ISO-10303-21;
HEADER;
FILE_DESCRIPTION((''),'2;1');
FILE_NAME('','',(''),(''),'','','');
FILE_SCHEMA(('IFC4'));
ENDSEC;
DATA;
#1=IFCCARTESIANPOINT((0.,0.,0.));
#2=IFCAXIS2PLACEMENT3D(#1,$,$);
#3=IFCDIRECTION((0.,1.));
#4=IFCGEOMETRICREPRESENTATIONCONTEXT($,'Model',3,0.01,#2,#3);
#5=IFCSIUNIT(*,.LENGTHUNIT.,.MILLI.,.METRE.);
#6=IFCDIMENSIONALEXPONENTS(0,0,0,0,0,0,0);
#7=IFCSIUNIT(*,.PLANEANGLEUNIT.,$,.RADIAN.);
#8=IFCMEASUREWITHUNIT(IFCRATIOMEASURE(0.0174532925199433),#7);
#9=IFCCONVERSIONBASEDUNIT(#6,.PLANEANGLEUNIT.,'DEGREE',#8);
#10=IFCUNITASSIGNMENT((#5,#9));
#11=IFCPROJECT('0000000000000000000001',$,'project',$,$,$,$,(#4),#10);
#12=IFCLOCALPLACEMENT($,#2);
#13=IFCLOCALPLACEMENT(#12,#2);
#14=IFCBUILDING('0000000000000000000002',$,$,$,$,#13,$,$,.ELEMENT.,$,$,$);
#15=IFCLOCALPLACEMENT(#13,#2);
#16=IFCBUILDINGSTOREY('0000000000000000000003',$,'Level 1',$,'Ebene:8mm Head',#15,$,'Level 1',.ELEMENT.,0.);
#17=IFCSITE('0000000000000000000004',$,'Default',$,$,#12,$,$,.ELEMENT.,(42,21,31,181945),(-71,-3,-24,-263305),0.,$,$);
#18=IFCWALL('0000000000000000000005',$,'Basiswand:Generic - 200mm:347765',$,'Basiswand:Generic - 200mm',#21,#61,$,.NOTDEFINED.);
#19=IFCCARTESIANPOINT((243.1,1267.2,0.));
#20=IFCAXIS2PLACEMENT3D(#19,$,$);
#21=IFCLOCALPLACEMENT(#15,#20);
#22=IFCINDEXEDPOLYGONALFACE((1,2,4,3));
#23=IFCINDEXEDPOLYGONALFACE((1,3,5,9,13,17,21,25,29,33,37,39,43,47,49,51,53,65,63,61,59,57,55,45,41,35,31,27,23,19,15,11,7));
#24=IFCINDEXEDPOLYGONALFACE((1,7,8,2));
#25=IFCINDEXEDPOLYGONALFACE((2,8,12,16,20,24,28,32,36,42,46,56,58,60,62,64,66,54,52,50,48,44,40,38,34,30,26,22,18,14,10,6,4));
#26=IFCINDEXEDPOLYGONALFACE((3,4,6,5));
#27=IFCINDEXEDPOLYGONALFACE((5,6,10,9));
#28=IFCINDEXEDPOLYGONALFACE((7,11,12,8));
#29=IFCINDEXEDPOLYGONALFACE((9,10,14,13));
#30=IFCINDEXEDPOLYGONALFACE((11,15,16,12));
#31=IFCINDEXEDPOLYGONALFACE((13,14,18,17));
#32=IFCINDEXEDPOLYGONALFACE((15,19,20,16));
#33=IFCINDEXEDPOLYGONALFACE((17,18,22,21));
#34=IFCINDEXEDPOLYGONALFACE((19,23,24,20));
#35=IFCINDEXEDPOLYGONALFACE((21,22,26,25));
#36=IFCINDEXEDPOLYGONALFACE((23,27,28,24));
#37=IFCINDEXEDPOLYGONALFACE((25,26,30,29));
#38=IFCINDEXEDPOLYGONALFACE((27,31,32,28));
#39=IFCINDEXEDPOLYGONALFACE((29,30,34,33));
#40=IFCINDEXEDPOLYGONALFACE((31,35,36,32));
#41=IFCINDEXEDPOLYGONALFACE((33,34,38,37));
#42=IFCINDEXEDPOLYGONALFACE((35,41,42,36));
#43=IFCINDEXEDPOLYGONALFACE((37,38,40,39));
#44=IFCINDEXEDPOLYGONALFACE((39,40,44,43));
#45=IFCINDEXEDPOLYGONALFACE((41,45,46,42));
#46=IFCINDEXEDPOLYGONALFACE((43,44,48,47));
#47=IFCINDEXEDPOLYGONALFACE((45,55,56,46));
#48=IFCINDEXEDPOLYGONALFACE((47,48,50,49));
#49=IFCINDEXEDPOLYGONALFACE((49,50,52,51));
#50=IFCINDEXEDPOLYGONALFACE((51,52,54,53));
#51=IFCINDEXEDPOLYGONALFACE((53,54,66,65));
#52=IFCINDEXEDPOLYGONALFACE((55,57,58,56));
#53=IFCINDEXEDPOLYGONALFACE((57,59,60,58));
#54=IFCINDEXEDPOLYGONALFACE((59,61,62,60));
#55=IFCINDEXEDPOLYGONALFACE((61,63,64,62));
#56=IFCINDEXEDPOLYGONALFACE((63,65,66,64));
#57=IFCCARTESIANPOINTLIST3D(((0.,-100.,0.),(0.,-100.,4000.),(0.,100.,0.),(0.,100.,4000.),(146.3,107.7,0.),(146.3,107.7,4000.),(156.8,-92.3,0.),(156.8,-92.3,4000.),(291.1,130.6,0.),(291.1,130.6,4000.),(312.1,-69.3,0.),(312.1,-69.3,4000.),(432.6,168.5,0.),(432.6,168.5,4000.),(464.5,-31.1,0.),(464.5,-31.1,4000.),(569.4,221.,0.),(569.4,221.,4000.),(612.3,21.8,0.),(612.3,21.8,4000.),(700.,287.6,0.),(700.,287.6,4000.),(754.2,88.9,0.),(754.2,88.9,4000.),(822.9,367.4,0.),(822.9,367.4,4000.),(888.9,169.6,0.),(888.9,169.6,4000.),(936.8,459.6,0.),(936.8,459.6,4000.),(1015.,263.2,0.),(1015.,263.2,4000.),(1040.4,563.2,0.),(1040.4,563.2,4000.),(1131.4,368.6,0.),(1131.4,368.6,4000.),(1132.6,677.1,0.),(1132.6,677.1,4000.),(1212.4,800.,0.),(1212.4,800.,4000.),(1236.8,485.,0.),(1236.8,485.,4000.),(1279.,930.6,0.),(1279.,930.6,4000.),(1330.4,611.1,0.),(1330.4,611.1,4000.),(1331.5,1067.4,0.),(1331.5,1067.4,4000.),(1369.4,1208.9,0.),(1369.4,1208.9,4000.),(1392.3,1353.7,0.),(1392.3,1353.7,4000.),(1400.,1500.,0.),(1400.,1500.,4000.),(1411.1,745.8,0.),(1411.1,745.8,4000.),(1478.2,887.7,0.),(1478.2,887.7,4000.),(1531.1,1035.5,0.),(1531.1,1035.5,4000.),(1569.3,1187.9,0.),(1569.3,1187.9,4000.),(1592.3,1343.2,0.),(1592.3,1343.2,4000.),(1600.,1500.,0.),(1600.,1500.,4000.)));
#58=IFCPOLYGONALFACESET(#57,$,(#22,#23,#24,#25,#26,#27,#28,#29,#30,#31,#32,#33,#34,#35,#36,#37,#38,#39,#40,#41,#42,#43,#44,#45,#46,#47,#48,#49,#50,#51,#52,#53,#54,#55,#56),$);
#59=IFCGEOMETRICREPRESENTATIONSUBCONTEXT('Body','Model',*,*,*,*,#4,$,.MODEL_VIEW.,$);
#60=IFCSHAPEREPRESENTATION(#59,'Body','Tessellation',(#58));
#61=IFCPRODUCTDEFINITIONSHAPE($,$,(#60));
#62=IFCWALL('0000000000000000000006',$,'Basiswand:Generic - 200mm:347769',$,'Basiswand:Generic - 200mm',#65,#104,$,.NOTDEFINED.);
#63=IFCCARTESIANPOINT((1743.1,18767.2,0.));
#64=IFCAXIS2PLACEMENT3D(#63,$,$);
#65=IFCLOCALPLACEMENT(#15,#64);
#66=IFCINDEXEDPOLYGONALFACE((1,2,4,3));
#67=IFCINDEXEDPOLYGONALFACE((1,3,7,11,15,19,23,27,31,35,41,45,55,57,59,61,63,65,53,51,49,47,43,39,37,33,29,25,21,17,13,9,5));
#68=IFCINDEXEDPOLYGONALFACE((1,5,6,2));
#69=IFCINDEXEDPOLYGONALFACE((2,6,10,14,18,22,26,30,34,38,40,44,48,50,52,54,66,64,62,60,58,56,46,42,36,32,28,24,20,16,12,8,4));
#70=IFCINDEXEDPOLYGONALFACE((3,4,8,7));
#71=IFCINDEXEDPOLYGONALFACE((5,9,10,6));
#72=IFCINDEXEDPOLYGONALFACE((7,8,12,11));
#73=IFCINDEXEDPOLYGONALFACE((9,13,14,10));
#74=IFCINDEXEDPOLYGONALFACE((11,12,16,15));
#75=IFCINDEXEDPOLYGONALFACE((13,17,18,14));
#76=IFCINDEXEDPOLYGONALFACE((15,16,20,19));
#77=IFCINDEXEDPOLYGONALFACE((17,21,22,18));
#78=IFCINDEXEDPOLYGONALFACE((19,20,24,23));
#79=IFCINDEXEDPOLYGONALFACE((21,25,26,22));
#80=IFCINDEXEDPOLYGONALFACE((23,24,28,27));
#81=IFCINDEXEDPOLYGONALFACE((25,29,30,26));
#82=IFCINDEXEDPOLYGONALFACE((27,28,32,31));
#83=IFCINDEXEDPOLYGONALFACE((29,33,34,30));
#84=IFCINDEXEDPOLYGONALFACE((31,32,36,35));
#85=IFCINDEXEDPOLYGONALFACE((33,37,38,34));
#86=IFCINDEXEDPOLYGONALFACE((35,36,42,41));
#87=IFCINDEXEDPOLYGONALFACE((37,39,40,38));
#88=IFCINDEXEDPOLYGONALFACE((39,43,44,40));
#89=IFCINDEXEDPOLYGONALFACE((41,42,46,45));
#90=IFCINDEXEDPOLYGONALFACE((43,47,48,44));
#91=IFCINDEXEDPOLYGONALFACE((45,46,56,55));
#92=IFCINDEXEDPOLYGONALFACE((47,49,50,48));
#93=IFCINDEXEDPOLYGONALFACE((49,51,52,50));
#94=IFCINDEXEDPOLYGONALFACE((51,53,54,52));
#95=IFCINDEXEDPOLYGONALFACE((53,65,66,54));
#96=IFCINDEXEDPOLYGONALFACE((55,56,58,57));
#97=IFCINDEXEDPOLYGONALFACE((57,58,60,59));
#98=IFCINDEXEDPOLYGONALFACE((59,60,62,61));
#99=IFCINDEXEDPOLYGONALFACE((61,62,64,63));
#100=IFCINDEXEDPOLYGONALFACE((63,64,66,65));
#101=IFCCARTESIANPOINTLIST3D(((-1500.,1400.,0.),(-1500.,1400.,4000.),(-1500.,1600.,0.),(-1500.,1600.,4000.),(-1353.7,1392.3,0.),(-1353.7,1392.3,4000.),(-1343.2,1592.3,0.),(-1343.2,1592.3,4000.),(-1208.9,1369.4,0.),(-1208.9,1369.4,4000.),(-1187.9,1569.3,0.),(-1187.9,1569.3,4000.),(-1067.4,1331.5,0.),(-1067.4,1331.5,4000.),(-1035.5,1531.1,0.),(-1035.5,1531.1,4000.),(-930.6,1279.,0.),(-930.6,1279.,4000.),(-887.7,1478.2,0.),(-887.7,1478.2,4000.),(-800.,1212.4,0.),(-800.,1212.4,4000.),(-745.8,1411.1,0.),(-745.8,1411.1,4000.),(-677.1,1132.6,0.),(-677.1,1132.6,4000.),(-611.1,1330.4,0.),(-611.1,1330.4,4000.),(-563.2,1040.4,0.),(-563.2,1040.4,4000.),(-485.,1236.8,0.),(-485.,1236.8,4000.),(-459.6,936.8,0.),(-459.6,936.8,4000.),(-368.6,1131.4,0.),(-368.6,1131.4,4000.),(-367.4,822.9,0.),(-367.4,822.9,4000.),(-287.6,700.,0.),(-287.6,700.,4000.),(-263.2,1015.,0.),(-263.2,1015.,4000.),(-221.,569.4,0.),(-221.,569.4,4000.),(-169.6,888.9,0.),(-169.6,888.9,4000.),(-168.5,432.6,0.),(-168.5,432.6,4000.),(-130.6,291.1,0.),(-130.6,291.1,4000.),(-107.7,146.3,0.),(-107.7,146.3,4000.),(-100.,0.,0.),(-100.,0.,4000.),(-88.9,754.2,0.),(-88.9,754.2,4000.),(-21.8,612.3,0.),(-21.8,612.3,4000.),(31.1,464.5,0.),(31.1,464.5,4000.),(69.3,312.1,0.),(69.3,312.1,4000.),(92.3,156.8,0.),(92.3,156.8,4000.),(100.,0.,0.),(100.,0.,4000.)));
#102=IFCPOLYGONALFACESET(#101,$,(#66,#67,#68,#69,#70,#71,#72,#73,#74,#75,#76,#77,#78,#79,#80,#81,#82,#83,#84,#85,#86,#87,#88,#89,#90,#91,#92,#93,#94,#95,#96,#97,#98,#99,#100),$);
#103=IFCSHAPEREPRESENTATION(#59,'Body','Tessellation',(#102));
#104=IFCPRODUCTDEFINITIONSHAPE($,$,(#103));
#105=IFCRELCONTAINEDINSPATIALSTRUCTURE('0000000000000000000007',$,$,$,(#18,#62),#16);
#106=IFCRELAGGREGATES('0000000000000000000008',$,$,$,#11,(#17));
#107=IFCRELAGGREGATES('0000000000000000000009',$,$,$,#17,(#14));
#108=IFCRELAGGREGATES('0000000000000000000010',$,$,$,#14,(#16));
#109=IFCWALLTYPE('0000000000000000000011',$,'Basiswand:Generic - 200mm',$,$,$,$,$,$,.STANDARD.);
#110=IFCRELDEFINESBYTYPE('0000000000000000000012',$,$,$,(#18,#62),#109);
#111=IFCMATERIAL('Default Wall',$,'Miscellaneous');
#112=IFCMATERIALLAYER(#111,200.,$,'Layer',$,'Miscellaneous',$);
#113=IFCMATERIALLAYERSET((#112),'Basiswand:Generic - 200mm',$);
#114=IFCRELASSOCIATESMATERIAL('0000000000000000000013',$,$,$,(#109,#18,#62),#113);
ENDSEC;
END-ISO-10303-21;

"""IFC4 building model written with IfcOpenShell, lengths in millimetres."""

from ifc_helpers import new_model, entity, si_unit, converted_unit, direction, frame, frame_2d, origin, place, context, subcontext, project, spatial, polyline, circle_curve, parameter, trimmed, segment, composite_curve, outline, extrude, material, layer, layer_set, layer_usage, type_object, element, save


model = new_model("IFC4")

# Units and contexts
model_context = context("Model", 3, precision=0.01, world=origin(), true_north=direction((0.0, 1.0)))
body_context = subcontext(model_context, "Body", "Model", "MODEL_VIEW")
ifc_project = project(units=[si_unit("LENGTHUNIT", "METRE", prefix="MILLI"), converted_unit("PLANEANGLEUNIT", "DEGREE", entity("IfcRatioMeasure", 0.0174532925199433), si_unit("PLANEANGLEUNIT", "RADIAN"), dimensions=[0, 0, 0, 0, 0, 0, 0])], contexts=[model_context])

# Site, building, storey
site_placement = place(None, origin())
site = spatial("IfcSite", under=ifc_project, at=site_placement, Name="Default", CompositionType="ELEMENT", RefLatitude=(42, 21, 31, 181945), RefLongitude=(-71, -3, -24, -263305), RefElevation=0.0)
building_placement = place(site_placement, origin())
building = spatial("IfcBuilding", under=site, at=building_placement, CompositionType="ELEMENT")
storey_placement = place(building_placement, origin())
storey = spatial("IfcBuildingStorey", under=building, at=storey_placement, Name="Level 1", ObjectType="Ebene:8mm Head", LongName="Level 1", CompositionType="ELEMENT", Elevation=0.0)

# Walls
ifc_material = material(Name="Default Wall", Category="Miscellaneous")
ifc_layer = layer(ifc_material, 200.0, Name="Layer", Category="Miscellaneous")
ifc_layer_set = layer_set([ifc_layer], Name="Basiswand:Generic - 200mm")
wall_type = type_object("IfcWallType", Name="Basiswand:Generic - 200mm", PredefinedType="STANDARD", material=ifc_layer_set)
ifc_layer_usage_1 = layer_usage(ifc_layer_set, "AXIS2", "NEGATIVE", 100.0)
wall_1_placement = place(storey_placement, frame((243.1, 1267.2, 0.0)))
element("IfcWall", 1, at=wall_1_placement, inside=storey, type_object=wall_type, material=ifc_layer_usage_1, Name="Basiswand:Generic - 200mm:347765", ObjectType="Basiswand:Generic - 200mm", PredefinedType="NOTDEFINED", context=body_context, shape_type="SweptSolid", body=[
    extrude(outline(composite_curve([segment(trimmed(circle_curve(frame_2d((0.0, 1500.0), x_axis=(1.0, 0.0)), 1400.0), [parameter(270.0)], [parameter(360.0)], True, "PARAMETER"), False, "CONTINUOUS"), segment(polyline([(0.0, 100.0), (0.0, -100.0)]), True, "CONTINUOUS"), segment(trimmed(circle_curve(frame_2d((0.0, 1500.0), x_axis=(1.0, 0.0)), 1600.0), [parameter(270.0)], [parameter(360.0)], True, "PARAMETER"), True, "CONTINUOUS"), segment(polyline([(1600.0, 1500.0), (1400.0, 1500.0)]), True, "CONTINUOUS")], self_intersect=False)), origin(), (0.0, 0.0, 1.0), 4000.0),
])
ifc_layer_usage_2 = layer_usage(ifc_layer_set, "AXIS2", "NEGATIVE", 100.0)
wall_2_placement = place(storey_placement, frame((1743.1, 18767.2, 0.0)))
element("IfcWall", 2, at=wall_2_placement, inside=storey, type_object=wall_type, material=ifc_layer_usage_2, Name="Basiswand:Generic - 200mm:347769", ObjectType="Basiswand:Generic - 200mm", PredefinedType="NOTDEFINED", context=body_context, shape_type="SweptSolid", body=[
    extrude(outline(composite_curve([segment(trimmed(circle_curve(frame_2d((-1500.0, 0.0), x_axis=(1.0, 0.0)), 1400.0), [parameter(0.0)], [parameter(90.0)], True, "PARAMETER"), False, "CONTINUOUS"), segment(polyline([(-100.0, 0.0), (100.0, 0.0)]), True, "CONTINUOUS"), segment(trimmed(circle_curve(frame_2d((-1500.0, 0.0), x_axis=(1.0, 0.0)), 1600.0), [parameter(0.0)], [parameter(90.0)], True, "PARAMETER"), True, "CONTINUOUS"), segment(polyline([(-1500.0, 1600.0), (-1500.0, 1400.0)]), True, "CONTINUOUS")], self_intersect=False)), origin(), (0.0, 0.0, 1.0), 4000.0),
])

save(model, "model.ifc")
